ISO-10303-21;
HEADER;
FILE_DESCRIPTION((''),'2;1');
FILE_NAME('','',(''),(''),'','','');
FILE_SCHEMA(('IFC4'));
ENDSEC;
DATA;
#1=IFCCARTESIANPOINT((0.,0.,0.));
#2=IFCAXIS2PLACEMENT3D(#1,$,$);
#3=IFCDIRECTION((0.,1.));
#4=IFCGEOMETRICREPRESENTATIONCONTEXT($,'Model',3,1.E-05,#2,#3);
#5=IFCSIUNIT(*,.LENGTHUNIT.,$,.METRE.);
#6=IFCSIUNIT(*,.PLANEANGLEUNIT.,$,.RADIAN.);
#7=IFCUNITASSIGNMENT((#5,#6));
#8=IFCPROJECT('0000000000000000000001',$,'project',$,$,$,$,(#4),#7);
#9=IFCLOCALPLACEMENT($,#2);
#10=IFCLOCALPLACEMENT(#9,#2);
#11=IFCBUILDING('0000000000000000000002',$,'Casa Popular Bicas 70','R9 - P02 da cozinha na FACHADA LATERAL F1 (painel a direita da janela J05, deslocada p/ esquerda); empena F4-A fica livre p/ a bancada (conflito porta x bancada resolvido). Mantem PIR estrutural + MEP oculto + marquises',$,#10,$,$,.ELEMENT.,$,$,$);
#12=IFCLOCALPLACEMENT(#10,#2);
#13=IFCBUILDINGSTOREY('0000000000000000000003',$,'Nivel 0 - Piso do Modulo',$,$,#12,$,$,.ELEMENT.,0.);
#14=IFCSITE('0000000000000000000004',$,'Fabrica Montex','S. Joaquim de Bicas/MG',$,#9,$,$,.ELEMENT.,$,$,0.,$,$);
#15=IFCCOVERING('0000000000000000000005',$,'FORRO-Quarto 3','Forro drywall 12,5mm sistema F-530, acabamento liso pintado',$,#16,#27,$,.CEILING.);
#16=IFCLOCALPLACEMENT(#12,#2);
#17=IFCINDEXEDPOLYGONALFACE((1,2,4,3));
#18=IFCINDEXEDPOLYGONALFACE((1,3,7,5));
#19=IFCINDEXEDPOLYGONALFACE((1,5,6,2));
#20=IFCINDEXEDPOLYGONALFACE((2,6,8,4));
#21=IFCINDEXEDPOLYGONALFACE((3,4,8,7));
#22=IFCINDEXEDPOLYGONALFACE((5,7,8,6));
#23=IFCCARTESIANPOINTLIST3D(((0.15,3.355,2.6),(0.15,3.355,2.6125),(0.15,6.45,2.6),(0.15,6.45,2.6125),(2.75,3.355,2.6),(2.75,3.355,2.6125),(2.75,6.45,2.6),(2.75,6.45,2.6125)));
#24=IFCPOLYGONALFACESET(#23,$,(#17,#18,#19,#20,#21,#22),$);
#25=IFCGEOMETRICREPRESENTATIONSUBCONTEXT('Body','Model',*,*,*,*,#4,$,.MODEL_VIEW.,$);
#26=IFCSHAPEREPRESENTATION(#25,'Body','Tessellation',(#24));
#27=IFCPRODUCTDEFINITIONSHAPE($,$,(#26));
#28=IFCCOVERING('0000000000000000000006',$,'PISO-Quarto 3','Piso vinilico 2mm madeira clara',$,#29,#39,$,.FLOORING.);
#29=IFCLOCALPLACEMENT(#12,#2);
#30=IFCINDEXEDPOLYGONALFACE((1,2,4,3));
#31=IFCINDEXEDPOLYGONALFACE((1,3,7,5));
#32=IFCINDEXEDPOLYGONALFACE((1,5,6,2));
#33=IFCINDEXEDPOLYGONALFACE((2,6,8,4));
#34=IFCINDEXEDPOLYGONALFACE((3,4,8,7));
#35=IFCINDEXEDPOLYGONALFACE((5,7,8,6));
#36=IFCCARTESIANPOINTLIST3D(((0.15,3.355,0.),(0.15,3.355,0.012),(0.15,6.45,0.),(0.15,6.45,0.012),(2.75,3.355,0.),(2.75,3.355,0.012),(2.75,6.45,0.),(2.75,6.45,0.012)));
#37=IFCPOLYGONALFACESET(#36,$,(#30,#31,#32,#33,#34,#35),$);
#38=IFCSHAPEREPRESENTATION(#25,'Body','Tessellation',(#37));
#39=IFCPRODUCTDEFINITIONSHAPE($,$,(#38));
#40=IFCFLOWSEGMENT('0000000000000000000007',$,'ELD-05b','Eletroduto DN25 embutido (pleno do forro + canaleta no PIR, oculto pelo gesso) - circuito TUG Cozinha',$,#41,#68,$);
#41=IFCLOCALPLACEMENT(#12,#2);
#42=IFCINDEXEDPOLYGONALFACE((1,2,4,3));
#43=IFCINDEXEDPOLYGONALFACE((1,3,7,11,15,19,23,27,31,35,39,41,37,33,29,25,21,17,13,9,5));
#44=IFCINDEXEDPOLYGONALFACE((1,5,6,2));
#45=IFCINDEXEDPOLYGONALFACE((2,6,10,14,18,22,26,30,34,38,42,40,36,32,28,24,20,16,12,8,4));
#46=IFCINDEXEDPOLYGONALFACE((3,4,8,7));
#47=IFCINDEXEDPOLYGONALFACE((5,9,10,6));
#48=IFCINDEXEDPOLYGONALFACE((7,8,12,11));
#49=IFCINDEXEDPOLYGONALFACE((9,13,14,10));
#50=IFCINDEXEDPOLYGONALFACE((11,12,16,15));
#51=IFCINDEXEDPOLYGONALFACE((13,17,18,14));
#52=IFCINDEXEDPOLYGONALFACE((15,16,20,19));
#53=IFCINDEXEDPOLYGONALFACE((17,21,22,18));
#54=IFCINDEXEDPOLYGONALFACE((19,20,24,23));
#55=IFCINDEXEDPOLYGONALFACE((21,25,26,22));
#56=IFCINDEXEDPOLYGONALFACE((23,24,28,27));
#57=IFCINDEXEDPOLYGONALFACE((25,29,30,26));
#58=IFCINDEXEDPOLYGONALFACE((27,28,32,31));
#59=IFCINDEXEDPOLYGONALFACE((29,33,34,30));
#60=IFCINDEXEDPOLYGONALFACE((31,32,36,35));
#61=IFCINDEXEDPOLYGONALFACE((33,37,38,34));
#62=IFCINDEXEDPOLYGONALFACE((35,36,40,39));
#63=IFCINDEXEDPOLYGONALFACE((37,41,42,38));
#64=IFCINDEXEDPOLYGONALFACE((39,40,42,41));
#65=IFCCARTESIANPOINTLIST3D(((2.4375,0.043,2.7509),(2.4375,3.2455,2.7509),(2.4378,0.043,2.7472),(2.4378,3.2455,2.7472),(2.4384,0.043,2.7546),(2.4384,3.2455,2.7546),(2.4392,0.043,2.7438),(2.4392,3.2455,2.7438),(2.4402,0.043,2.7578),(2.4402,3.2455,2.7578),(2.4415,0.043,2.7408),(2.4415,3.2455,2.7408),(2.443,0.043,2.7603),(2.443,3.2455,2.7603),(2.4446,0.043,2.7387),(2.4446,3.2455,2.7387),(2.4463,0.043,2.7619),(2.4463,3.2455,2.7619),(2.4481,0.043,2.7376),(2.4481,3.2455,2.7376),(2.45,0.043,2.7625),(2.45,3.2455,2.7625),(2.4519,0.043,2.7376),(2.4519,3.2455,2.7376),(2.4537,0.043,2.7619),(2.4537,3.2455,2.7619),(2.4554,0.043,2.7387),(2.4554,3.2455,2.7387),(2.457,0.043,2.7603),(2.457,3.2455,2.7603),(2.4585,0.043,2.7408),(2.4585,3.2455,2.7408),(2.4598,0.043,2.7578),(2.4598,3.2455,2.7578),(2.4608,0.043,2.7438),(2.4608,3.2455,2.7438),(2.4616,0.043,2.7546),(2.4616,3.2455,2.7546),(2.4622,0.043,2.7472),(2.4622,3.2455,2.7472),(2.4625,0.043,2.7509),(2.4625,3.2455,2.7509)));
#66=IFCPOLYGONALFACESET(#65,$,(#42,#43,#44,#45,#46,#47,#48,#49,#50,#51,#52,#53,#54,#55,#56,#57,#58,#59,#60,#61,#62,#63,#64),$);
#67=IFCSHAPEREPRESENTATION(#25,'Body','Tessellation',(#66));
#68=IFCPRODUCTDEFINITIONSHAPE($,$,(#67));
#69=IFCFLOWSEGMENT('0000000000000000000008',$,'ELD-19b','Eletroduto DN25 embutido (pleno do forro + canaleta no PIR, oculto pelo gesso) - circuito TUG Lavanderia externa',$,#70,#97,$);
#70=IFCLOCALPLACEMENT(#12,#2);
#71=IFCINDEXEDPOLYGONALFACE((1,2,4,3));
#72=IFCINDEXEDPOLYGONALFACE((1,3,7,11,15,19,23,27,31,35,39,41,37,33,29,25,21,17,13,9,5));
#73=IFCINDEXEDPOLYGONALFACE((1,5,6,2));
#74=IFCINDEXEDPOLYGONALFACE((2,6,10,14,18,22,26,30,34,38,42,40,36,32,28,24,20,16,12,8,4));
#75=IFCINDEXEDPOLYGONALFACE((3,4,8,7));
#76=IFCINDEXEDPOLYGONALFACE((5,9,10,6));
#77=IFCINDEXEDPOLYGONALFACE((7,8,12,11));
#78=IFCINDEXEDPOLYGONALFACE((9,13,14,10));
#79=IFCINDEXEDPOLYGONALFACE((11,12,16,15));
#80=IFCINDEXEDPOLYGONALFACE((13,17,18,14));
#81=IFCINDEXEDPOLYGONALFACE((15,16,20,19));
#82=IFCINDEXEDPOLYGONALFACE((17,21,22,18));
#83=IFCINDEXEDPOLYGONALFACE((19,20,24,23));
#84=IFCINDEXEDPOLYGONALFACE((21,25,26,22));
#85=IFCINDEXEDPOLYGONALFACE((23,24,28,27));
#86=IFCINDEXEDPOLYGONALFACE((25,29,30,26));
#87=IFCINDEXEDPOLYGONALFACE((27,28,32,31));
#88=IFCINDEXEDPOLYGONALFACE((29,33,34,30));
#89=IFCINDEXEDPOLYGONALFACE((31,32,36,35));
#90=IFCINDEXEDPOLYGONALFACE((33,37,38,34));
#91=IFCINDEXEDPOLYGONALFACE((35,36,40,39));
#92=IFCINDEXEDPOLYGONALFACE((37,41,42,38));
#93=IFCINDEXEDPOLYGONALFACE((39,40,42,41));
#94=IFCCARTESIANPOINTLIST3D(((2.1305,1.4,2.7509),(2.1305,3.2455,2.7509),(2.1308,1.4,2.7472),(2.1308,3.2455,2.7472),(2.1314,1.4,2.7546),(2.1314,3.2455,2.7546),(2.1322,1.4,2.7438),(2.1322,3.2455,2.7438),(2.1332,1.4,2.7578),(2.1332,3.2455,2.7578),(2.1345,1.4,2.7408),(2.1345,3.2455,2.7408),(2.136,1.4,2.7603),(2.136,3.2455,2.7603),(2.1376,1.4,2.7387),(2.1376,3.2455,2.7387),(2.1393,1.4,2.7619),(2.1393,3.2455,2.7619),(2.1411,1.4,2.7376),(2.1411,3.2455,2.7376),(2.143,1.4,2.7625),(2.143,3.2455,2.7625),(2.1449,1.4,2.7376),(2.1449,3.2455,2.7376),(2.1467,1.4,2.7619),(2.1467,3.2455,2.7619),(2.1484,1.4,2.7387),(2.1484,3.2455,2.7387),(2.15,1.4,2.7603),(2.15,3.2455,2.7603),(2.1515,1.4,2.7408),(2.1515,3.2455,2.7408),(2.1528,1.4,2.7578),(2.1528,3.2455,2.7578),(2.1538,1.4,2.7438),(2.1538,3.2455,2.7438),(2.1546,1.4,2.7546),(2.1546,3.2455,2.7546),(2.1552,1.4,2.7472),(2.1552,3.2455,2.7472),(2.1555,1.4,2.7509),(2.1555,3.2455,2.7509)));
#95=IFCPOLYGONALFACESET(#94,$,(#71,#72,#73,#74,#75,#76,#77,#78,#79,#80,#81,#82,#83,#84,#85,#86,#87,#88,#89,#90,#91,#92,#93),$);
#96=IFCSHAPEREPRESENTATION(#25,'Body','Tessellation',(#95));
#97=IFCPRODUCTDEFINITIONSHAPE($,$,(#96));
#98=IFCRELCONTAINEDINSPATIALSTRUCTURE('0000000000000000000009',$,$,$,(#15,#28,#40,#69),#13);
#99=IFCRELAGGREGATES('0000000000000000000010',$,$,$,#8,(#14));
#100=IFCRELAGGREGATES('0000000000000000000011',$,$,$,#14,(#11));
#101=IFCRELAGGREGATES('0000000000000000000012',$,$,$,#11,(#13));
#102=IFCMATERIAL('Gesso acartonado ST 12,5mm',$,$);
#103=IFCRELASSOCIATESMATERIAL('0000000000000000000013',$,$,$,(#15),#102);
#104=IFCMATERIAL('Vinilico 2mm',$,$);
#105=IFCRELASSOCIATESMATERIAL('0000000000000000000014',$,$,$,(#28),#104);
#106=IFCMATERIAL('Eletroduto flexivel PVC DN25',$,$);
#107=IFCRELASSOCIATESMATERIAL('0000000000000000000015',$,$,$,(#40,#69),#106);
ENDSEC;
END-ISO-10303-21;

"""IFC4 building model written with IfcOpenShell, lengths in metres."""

from ifc_helpers import new_model, si_unit, direction, frame, frame_2d, origin, origin_2d, place, context, subcontext, project, spatial, rectangle, circle, extrude, material, element, save


model = new_model("IFC4")

# Units and contexts
model_context = context("Model", 3, precision=1e-05, world=origin(), true_north=direction((0.0, 1.0)))
body_context = subcontext(model_context, "Body", "Model", "MODEL_VIEW")
ifc_project = project(units=[si_unit("LENGTHUNIT", "METRE"), si_unit("PLANEANGLEUNIT", "RADIAN")], contexts=[model_context])

# Site, building, storey
site_placement = place(None, origin())
site = spatial("IfcSite", under=ifc_project, at=site_placement, Name="Fabrica Montex", Description="S. Joaquim de Bicas/MG", CompositionType="ELEMENT", RefElevation=0.0)
building_placement = place(site_placement, origin())
building = spatial("IfcBuilding", under=site, at=building_placement, Name="Casa Popular Bicas 70", Description="R9 - P02 da cozinha na FACHADA LATERAL F1 (painel a direita da janela J05, deslocada p/ esquerda); empena F4-A fica livre p/ a bancada (conflito porta x bancada resolvido). Mantem PIR estrutural + MEP oculto + marquises", CompositionType="ELEMENT")
storey_placement = place(building_placement, origin())
storey = spatial("IfcBuildingStorey", under=building, at=storey_placement, Name="Nivel 0 - Piso do Modulo", CompositionType="ELEMENT", Elevation=0.0)

# Coverings
ifc_material_1 = material(Name="Gesso acartonado ST 12,5mm")
covering_1_placement = place(storey_placement, frame((0.15, 3.355, 2.6)))
element("IfcCovering", 1, at=covering_1_placement, inside=storey, material=ifc_material_1, Name="FORRO-Quarto 3", Description="Forro drywall 12,5mm sistema F-530, acabamento liso pintado", PredefinedType="CEILING", context=body_context, shape_type="SweptSolid", body=[
    extrude(rectangle(XDim=2.6, YDim=3.095, at=frame_2d((1.3, 1.5475))), origin(), (0.0, 0.0, 1.0), 0.0125),
])
ifc_material_2 = material(Name="Vinilico 2mm")
covering_2_placement = place(storey_placement, frame((0.15, 3.355, 0.0)))
element("IfcCovering", 2, at=covering_2_placement, inside=storey, material=ifc_material_2, Name="PISO-Quarto 3", Description="Piso vinilico 2mm madeira clara", PredefinedType="FLOORING", context=body_context, shape_type="SweptSolid", body=[
    extrude(rectangle(XDim=2.6, YDim=3.095, at=frame_2d((1.3, 1.5475))), origin(), (0.0, 0.0, 1.0), 0.012),
])

# Flow segments
ifc_material_3 = material(Name="Eletroduto flexivel PVC DN25")
flow_segment_1_placement = place(storey_placement, frame((2.45, 3.2455, 2.75), z_axis=(0.0, -1.0, 0.0), x_axis=(0.0, 0.0, 1.0)))
element("IfcFlowSegment", 3, at=flow_segment_1_placement, inside=storey, material=ifc_material_3, Name="ELD-05b", Description="Eletroduto DN25 embutido (pleno do forro + canaleta no PIR, oculto pelo gesso) - circuito TUG Cozinha", context=body_context, shape_type="SweptSolid", body=[
    extrude(circle(Radius=0.0125, at=origin_2d()), origin(), (0.0, 0.0, 1.0), 3.2025),
])
flow_segment_2_placement = place(storey_placement, frame((2.143, 3.2455, 2.75), z_axis=(0.0, -1.0, 0.0), x_axis=(0.0, 0.0, 1.0)))
element("IfcFlowSegment", 4, at=flow_segment_2_placement, inside=storey, material=ifc_material_3, Name="ELD-19b", Description="Eletroduto DN25 embutido (pleno do forro + canaleta no PIR, oculto pelo gesso) - circuito TUG Lavanderia externa", context=body_context, shape_type="SweptSolid", body=[
    extrude(circle(Radius=0.0125, at=origin_2d()), origin(), (0.0, 0.0, 1.0), 1.8455),
])

save(model, "model.ifc")
